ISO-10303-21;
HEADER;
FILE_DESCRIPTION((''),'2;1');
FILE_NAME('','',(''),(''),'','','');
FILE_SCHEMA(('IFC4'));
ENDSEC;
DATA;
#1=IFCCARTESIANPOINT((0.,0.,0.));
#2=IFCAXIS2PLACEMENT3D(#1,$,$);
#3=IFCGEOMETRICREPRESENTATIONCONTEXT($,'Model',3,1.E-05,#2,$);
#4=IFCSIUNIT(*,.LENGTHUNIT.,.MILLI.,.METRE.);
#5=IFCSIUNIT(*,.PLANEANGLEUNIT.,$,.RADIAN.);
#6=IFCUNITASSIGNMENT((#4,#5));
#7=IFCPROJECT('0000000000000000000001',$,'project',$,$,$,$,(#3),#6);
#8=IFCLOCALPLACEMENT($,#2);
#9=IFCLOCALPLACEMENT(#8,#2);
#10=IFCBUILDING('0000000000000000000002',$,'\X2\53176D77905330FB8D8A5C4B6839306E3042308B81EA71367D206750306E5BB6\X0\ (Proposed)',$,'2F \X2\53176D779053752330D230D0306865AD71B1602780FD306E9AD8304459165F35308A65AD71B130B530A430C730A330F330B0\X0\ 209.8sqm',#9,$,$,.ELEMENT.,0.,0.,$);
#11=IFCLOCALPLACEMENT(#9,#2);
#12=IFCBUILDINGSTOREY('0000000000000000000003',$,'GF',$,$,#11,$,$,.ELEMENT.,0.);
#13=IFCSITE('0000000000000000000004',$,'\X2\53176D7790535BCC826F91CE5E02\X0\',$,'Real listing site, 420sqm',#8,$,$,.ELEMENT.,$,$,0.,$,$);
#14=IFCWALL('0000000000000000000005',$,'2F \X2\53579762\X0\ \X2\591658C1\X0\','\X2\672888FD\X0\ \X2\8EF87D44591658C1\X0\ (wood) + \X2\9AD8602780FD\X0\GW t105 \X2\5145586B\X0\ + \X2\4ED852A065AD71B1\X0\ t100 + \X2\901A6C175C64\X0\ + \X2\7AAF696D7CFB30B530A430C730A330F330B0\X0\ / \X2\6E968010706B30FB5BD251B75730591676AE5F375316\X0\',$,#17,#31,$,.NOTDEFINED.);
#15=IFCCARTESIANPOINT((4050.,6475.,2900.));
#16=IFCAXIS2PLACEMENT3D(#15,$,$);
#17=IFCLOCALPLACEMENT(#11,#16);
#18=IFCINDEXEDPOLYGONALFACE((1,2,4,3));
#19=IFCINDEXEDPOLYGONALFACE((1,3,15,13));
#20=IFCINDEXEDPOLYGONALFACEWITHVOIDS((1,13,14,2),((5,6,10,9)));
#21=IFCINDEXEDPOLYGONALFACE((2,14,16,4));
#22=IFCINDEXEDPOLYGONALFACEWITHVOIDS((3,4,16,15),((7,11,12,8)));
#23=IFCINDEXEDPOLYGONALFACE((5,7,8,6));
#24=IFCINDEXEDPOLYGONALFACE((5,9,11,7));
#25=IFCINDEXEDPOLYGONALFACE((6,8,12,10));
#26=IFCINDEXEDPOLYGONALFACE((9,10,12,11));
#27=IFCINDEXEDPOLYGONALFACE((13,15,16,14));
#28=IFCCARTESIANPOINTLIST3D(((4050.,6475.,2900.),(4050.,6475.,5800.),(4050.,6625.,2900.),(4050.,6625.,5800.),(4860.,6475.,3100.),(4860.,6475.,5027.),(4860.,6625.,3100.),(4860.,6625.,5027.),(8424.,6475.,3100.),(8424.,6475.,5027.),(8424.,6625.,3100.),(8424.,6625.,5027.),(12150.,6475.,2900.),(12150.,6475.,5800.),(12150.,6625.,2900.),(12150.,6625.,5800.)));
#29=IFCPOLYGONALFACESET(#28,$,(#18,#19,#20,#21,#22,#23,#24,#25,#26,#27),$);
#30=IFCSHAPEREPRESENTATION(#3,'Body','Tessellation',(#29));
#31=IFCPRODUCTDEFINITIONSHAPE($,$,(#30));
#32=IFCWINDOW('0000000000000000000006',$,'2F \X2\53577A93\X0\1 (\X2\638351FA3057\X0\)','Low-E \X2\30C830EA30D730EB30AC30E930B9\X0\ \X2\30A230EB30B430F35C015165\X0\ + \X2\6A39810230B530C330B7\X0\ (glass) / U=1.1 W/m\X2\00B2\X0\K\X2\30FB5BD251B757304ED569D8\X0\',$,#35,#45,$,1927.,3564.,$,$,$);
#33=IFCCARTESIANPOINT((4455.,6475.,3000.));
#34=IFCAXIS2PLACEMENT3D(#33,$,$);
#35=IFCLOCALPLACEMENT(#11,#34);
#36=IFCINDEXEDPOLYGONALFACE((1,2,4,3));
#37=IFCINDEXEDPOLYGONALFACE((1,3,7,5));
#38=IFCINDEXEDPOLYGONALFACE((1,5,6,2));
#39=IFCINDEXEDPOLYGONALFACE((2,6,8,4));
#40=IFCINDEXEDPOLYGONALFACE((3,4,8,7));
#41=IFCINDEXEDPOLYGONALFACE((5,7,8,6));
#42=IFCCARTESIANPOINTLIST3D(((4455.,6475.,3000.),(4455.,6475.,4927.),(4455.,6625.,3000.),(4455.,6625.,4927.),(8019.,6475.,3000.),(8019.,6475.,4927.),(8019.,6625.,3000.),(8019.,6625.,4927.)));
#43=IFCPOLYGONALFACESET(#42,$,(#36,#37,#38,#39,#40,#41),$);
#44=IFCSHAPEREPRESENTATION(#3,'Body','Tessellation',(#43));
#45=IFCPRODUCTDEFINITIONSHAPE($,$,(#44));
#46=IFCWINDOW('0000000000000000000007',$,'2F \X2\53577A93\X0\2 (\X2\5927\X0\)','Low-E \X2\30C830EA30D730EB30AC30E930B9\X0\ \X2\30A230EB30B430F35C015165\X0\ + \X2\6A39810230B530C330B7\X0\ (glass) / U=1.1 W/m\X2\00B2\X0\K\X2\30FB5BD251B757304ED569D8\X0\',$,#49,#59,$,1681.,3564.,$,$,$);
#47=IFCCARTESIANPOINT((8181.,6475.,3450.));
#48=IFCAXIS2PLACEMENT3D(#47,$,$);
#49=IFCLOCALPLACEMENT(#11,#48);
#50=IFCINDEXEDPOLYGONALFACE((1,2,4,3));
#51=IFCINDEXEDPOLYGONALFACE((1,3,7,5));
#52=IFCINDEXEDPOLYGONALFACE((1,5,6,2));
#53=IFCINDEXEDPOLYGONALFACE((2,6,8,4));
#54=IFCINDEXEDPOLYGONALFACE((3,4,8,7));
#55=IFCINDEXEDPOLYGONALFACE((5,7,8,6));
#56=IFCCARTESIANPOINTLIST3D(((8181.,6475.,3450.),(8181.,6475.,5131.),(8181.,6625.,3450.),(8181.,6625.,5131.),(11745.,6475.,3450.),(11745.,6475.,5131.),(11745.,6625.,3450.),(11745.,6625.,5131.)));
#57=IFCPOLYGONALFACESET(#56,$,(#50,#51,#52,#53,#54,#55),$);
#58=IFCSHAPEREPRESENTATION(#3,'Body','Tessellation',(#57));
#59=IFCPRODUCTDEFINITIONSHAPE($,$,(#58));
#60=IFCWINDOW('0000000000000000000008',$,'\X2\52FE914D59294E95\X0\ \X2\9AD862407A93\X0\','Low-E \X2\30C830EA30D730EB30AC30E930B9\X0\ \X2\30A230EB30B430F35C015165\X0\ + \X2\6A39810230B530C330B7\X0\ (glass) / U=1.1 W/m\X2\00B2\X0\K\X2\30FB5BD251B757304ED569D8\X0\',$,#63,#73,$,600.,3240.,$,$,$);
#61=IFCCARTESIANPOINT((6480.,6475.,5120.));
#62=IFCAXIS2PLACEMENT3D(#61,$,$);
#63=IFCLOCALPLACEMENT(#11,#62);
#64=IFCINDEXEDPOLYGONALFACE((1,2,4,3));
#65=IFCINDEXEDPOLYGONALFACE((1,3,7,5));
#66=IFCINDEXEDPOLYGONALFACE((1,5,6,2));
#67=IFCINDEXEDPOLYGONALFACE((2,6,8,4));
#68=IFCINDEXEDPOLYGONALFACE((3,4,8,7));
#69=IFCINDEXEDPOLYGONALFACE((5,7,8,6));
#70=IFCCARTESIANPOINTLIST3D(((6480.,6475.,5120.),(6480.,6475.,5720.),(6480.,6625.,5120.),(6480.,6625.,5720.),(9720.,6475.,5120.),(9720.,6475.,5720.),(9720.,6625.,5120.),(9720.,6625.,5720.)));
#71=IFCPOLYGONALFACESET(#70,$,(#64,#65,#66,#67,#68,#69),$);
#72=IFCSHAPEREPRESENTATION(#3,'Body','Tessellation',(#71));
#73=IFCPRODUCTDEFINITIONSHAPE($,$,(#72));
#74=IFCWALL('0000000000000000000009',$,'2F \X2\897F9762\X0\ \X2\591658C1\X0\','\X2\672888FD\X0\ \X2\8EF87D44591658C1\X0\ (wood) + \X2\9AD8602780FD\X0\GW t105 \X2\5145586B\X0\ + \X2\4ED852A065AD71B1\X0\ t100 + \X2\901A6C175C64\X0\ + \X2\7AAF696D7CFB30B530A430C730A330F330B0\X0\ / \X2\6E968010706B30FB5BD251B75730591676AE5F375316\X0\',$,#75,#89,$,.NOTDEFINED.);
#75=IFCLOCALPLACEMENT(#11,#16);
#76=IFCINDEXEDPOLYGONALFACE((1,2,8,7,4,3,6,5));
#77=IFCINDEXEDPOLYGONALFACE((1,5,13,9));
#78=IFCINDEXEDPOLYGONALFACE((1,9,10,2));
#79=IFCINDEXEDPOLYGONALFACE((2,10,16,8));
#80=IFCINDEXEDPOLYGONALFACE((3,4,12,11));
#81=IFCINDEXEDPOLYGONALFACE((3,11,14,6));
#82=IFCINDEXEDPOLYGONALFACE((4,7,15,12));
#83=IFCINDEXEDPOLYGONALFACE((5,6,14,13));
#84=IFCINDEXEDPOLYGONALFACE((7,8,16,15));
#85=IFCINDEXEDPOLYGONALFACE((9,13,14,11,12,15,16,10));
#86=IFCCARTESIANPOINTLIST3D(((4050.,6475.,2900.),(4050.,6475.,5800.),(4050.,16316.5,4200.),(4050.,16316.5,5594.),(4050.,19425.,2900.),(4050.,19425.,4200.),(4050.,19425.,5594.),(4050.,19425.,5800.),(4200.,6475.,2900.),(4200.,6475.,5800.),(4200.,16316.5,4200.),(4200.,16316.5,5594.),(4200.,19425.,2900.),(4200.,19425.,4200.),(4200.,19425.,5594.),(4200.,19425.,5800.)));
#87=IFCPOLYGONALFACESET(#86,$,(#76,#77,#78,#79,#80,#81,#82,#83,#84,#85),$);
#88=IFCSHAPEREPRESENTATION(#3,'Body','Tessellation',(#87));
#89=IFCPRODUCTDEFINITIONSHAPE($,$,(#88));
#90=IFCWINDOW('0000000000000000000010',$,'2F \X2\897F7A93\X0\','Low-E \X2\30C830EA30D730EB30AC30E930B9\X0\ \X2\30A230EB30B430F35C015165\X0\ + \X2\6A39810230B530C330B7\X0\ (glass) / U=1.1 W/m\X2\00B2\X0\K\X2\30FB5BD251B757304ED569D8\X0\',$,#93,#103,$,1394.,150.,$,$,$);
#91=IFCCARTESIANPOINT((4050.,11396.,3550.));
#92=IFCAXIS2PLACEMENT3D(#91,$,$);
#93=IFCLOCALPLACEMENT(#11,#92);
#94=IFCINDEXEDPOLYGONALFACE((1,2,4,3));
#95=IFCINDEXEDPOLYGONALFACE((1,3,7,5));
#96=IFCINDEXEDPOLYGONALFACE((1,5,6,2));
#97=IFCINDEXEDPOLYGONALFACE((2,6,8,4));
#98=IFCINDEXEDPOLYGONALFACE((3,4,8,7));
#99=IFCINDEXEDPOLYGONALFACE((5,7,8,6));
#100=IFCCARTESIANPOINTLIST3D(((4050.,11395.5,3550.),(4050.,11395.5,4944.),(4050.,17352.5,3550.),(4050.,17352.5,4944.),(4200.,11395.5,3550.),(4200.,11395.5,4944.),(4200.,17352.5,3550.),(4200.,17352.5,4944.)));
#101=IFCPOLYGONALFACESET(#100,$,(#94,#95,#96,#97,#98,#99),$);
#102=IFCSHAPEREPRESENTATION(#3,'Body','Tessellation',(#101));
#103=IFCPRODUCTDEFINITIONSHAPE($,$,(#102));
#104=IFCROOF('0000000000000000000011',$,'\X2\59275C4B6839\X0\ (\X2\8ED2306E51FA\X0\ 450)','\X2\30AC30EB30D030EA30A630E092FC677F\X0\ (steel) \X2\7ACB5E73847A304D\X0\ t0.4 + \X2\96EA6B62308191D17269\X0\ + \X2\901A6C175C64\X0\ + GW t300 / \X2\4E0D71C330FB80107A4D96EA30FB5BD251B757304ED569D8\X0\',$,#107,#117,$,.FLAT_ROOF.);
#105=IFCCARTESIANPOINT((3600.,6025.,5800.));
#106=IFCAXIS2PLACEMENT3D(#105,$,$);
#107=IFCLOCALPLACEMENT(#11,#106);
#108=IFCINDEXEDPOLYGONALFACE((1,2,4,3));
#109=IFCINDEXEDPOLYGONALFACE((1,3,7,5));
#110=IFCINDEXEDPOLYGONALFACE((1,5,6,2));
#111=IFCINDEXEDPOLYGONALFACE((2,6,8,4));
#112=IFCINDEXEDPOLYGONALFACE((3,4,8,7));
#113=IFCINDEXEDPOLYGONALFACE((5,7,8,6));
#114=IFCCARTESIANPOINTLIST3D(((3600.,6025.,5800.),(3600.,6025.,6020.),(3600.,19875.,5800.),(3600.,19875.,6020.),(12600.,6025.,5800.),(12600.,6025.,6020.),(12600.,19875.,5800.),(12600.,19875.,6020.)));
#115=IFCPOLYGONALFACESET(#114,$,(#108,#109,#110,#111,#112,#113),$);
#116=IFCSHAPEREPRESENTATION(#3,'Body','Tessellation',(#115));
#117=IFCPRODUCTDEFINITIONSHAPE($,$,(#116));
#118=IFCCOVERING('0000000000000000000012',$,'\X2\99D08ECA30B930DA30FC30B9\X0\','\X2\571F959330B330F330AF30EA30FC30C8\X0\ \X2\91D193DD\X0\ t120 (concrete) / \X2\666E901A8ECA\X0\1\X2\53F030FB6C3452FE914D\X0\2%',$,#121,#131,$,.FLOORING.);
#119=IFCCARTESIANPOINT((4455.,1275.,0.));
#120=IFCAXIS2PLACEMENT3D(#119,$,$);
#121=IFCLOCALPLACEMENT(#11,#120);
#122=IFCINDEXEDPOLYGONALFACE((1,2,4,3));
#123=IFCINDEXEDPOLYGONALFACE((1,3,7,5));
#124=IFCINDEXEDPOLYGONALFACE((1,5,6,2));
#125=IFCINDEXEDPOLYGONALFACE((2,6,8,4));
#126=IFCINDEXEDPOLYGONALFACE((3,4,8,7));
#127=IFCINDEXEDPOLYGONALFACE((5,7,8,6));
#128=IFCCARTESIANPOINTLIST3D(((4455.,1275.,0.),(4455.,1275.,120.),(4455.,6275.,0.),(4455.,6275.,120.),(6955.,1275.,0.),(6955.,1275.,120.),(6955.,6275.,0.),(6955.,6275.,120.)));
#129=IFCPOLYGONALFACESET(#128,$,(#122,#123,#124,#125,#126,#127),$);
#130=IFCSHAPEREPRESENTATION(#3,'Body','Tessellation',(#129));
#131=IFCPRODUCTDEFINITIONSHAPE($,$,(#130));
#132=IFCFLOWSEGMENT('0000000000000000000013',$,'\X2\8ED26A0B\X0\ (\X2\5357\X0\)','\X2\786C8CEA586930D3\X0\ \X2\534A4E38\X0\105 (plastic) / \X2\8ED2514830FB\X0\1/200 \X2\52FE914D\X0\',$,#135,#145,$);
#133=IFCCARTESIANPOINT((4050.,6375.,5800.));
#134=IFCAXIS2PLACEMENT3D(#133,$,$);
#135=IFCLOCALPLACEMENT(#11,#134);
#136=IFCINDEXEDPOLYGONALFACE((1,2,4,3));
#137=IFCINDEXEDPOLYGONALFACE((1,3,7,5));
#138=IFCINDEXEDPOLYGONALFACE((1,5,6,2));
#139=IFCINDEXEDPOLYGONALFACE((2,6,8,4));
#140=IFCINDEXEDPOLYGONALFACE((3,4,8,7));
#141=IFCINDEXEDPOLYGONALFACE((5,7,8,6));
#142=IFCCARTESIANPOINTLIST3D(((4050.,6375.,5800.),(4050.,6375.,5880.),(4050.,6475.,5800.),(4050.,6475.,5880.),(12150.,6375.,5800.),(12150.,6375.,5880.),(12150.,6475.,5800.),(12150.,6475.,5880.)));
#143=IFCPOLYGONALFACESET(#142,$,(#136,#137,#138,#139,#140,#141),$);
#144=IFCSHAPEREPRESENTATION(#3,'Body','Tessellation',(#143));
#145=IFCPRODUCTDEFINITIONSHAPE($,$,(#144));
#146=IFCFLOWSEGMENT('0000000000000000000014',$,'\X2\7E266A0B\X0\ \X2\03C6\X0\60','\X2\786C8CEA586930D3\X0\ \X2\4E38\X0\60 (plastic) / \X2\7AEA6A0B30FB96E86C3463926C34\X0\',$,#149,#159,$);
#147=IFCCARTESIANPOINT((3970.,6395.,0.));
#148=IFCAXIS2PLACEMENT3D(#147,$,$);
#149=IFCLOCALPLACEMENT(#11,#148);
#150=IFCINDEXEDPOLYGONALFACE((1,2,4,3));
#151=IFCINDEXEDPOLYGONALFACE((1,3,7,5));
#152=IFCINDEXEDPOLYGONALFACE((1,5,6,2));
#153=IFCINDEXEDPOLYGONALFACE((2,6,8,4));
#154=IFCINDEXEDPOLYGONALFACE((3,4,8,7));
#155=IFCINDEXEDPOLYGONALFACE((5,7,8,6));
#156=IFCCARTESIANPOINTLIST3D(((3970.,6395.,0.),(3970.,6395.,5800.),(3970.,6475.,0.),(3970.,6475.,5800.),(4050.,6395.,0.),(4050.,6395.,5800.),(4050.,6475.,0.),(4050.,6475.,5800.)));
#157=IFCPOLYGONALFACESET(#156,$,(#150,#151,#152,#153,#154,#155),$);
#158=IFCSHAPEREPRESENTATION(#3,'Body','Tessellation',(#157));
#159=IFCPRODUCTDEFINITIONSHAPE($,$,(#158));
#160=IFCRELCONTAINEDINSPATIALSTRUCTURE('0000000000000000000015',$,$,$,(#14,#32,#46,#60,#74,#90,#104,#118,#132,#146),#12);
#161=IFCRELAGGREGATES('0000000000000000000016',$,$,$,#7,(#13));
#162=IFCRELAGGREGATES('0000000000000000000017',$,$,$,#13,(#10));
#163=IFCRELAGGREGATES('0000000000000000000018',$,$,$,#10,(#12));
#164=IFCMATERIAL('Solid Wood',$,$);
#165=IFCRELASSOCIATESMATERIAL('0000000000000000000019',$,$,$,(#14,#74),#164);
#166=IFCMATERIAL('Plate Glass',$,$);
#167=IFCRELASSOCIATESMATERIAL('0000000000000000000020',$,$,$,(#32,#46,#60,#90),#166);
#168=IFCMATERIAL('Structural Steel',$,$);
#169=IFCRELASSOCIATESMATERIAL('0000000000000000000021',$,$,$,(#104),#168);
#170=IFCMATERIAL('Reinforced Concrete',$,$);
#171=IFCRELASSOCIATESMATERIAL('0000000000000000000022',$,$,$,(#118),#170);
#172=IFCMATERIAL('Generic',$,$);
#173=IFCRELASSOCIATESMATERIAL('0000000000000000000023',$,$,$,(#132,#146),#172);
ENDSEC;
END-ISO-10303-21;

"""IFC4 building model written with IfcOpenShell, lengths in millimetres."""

from ifc_helpers import new_model, si_unit, frame, frame_2d, origin, place, context, project, spatial, rectangle, extrude, material, element, fill, save


model = new_model("IFC4")

# Units and contexts
model_context = context("Model", 3, precision=1e-05, world=origin())
ifc_project = project(units=[si_unit("LENGTHUNIT", "METRE", prefix="MILLI"), si_unit("PLANEANGLEUNIT", "RADIAN")], contexts=[model_context])

# Site, building, storey
site_placement = place(None, origin())
site = spatial("IfcSite", under=ifc_project, at=site_placement, Name="北海道富良野市", ObjectType="Real listing site, 420sqm", CompositionType="ELEMENT", RefElevation=0.0)
building_placement = place(site_placement, origin())
building = spatial("IfcBuilding", under=site, at=building_placement, Name="北海道・越屋根のある自然素材の家 (Proposed)", ObjectType="2F 北海道産ヒバと断熱性能の高い外張り断熱サイディング 209.8sqm", CompositionType="ELEMENT", ElevationOfRefHeight=0.0, ElevationOfTerrain=0.0)
storey_placement = place(building_placement, origin())
storey = spatial("IfcBuildingStorey", under=building, at=storey_placement, Name="GF", CompositionType="ELEMENT", Elevation=0.0)

# Shared definitions
ifc_material_1 = material(Name="Solid Wood")

# Shared definitions
ifc_material_2 = material(Name="Reinforced Concrete")

# Shared definitions
ifc_material_3 = material(Name="Plate Glass")

# Wall, openings, windows
wall_1_placement = place(storey_placement, frame((4050.0, 6475.0, 2900.0)))
wall_1 = element("IfcWall", 1, at=wall_1_placement, inside=storey, material=ifc_material_1, Name="2F 南面 外壁", Description="木製 軸組外壁 (wood) + 高性能GW t105 充填 + 付加断熱 t100 + 通気層 + 窯業系サイディング / 準耐火・寒冷地外皮強化", PredefinedType="NOTDEFINED", context=model_context, shape_type="SweptSolid", body=[
    extrude(rectangle(XDim=8100.0, YDim=150.0, at=frame_2d((4050.0, 75.0))), frame((4050.0, 6475.0, 2900.0)), (0.0, 0.0, 1.0), 2900.0),
])
opening_1_placement = place(storey_placement, frame((4455.0, 6475.0, 3000.0)))
opening_1 = element("IfcOpeningElement", 2, at=opening_1_placement, cuts=wall_1, PredefinedType="NOTDEFINED", context=model_context, shape_type="SweptSolid", body=[
    extrude(rectangle(XDim=3564.0, YDim=150.0, at=frame_2d((1782.0, 75.0))), frame((4455.0, 6475.0, 3000.0)), (0.0, 0.0, 1.0), 1927.0),
])
opening_2_placement = place(storey_placement, frame((8181.0, 6475.0, 3450.0)))
opening_2 = element("IfcOpeningElement", 3, at=opening_2_placement, cuts=wall_1, PredefinedType="NOTDEFINED", context=model_context, shape_type="SweptSolid", body=[
    extrude(rectangle(XDim=3564.0, YDim=150.0, at=frame_2d((1782.0, 75.0))), frame((8181.0, 6475.0, 3450.0)), (0.0, 0.0, 1.0), 1681.0),
])
opening_3_placement = place(storey_placement, frame((6480.0, 6475.0, 5120.0)))
opening_3 = element("IfcOpeningElement", 4, at=opening_3_placement, cuts=wall_1, PredefinedType="NOTDEFINED", context=model_context, shape_type="SweptSolid", body=[
    extrude(rectangle(XDim=3240.0, YDim=150.0, at=frame_2d((1620.0, 75.0))), frame((6480.0, 6475.0, 5120.0)), (0.0, 0.0, 1.0), 600.0),
])
window_1_placement = place(storey_placement, frame((4455.0, 6475.0, 3000.0)))
window_1 = element("IfcWindow", 5, at=window_1_placement, inside=storey, material=ifc_material_3, Name="2F 南窓1 (掃出し)", Description="Low-E トリプルガラス アルゴン封入 + 樹脂サッシ (glass) / U=1.1 W/m²K・寒冷地仕様", OverallHeight=1927.0, OverallWidth=3564.0, context=model_context, shape_type="SweptSolid", body=[
    extrude(rectangle(XDim=3564.0, YDim=150.0, at=frame_2d((1782.0, 75.0))), frame((4455.0, 6475.0, 3000.0)), (0.0, 0.0, 1.0), 1927.0),
])
fill(opening_1, window_1)
window_2_placement = place(storey_placement, frame((8181.0, 6475.0, 3450.0)))
window_2 = element("IfcWindow", 6, at=window_2_placement, inside=storey, material=ifc_material_3, Name="2F 南窓2 (大)", Description="Low-E トリプルガラス アルゴン封入 + 樹脂サッシ (glass) / U=1.1 W/m²K・寒冷地仕様", OverallHeight=1681.0, OverallWidth=3564.0, context=model_context, shape_type="SweptSolid", body=[
    extrude(rectangle(XDim=3564.0, YDim=150.0, at=frame_2d((1782.0, 75.0))), frame((8181.0, 6475.0, 3450.0)), (0.0, 0.0, 1.0), 1681.0),
])
fill(opening_2, window_2)
window_3_placement = place(storey_placement, frame((6480.0, 6475.0, 5120.0)))
window_3 = element("IfcWindow", 7, at=window_3_placement, inside=storey, material=ifc_material_3, Name="勾配天井 高所窓", Description="Low-E トリプルガラス アルゴン封入 + 樹脂サッシ (glass) / U=1.1 W/m²K・寒冷地仕様", OverallHeight=600.0, OverallWidth=3240.0, context=model_context, shape_type="SweptSolid", body=[
    extrude(rectangle(XDim=3240.0, YDim=150.0, at=frame_2d((1620.0, 75.0))), frame((6480.0, 6475.0, 5120.0)), (0.0, 0.0, 1.0), 600.0),
])
fill(opening_3, window_3)

# Wall, opening, window
wall_2_placement = place(storey_placement, frame((4050.0, 6475.0, 2900.0)))
wall_2 = element("IfcWall", 8, at=wall_2_placement, inside=storey, material=ifc_material_1, Name="2F 西面 外壁", Description="木製 軸組外壁 (wood) + 高性能GW t105 充填 + 付加断熱 t100 + 通気層 + 窯業系サイディング / 準耐火・寒冷地外皮強化", PredefinedType="NOTDEFINED", context=model_context, shape_type="SweptSolid", body=[
    extrude(rectangle(XDim=150.0, YDim=12950.0, at=frame_2d((75.0, 6475.0))), frame((4050.0, 6475.0, 2900.0)), (0.0, 0.0, 1.0), 2900.0),
])
opening_4_placement = place(storey_placement, frame((4050.0, 11396.0, 3550.0)))
opening_4 = element("IfcOpeningElement", 9, at=opening_4_placement, cuts=wall_2, PredefinedType="NOTDEFINED", context=model_context, shape_type="SweptSolid", body=[
    extrude(rectangle(XDim=150.0, YDim=5957.0, at=frame_2d((75.0, 2978.0))), frame((4050.0, 11396.0, 3550.0)), (0.0, 0.0, 1.0), 1394.0),
])
window_4_placement = place(storey_placement, frame((4050.0, 11396.0, 3550.0)))
window_4 = element("IfcWindow", 10, at=window_4_placement, inside=storey, material=ifc_material_3, Name="2F 西窓", Description="Low-E トリプルガラス アルゴン封入 + 樹脂サッシ (glass) / U=1.1 W/m²K・寒冷地仕様", OverallHeight=1394.0, OverallWidth=150.0, context=model_context, shape_type="SweptSolid", body=[
    extrude(rectangle(XDim=150.0, YDim=5957.0, at=frame_2d((75.0, 2978.0))), frame((4050.0, 11396.0, 3550.0)), (0.0, 0.0, 1.0), 1394.0),
])
fill(opening_4, window_4)

# Roof
ifc_material_4 = material(Name="Structural Steel")
roof_placement = place(storey_placement, frame((3600.0, 6025.0, 5800.0)))
element("IfcRoof", 11, at=roof_placement, inside=storey, material=ifc_material_4, Name="大屋根 (軒の出 450)", Description="ガルバリウム鋼板 (steel) 立平葺き t0.4 + 雪止め金物 + 通気層 + GW t300 / 不燃・耐積雪・寒冷地仕様", PredefinedType="FLAT_ROOF", context=model_context, shape_type="SweptSolid", body=[
    extrude(rectangle(XDim=9000.0, YDim=13850.0, at=frame_2d((4500.0, 6925.0))), frame((3600.0, 6025.0, 5800.0)), (0.0, 0.0, 1.0), 220.0),
])

# Covering
covering_placement = place(storey_placement, frame((4455.0, 1275.0, 0.0)))
element("IfcCovering", 12, at=covering_placement, inside=storey, material=ifc_material_2, Name="駐車スペース", Description="土間コンクリート 金鏝 t120 (concrete) / 普通車1台・水勾配2%", PredefinedType="FLOORING", context=model_context, shape_type="SweptSolid", body=[
    extrude(rectangle(XDim=2500.0, YDim=5000.0, at=frame_2d((1250.0, 2500.0))), frame((4455.0, 1275.0, 0.0)), (0.0, 0.0, 1.0), 120.0),
])

# Flow segments
ifc_material_5 = material(Name="Generic")
flow_segment_1_placement = place(storey_placement, frame((4050.0, 6375.0, 5800.0)))
element("IfcFlowSegment", 13, at=flow_segment_1_placement, inside=storey, material=ifc_material_5, Name="軒樋 (南)", Description="硬質塩ビ 半丸105 (plastic) / 軒先・1/200 勾配", context=model_context, shape_type="SweptSolid", body=[
    extrude(rectangle(XDim=8100.0, YDim=100.0, at=frame_2d((4050.0, 50.0))), frame((4050.0, 6375.0, 5800.0)), (0.0, 0.0, 1.0), 80.0),
])
flow_segment_2_placement = place(storey_placement, frame((3970.0, 6395.0, 0.0)))
element("IfcFlowSegment", 14, at=flow_segment_2_placement, inside=storey, material=ifc_material_5, Name="縦樋 φ60", Description="硬質塩ビ 丸60 (plastic) / 竪樋・雨水排水", context=model_context, shape_type="SweptSolid", body=[
    extrude(rectangle(XDim=80.0, YDim=80.0, at=frame_2d((40.0, 40.0))), frame((3970.0, 6395.0, 0.0)), (0.0, 0.0, 1.0), 5800.0),
])

save(model, "model.ifc")
